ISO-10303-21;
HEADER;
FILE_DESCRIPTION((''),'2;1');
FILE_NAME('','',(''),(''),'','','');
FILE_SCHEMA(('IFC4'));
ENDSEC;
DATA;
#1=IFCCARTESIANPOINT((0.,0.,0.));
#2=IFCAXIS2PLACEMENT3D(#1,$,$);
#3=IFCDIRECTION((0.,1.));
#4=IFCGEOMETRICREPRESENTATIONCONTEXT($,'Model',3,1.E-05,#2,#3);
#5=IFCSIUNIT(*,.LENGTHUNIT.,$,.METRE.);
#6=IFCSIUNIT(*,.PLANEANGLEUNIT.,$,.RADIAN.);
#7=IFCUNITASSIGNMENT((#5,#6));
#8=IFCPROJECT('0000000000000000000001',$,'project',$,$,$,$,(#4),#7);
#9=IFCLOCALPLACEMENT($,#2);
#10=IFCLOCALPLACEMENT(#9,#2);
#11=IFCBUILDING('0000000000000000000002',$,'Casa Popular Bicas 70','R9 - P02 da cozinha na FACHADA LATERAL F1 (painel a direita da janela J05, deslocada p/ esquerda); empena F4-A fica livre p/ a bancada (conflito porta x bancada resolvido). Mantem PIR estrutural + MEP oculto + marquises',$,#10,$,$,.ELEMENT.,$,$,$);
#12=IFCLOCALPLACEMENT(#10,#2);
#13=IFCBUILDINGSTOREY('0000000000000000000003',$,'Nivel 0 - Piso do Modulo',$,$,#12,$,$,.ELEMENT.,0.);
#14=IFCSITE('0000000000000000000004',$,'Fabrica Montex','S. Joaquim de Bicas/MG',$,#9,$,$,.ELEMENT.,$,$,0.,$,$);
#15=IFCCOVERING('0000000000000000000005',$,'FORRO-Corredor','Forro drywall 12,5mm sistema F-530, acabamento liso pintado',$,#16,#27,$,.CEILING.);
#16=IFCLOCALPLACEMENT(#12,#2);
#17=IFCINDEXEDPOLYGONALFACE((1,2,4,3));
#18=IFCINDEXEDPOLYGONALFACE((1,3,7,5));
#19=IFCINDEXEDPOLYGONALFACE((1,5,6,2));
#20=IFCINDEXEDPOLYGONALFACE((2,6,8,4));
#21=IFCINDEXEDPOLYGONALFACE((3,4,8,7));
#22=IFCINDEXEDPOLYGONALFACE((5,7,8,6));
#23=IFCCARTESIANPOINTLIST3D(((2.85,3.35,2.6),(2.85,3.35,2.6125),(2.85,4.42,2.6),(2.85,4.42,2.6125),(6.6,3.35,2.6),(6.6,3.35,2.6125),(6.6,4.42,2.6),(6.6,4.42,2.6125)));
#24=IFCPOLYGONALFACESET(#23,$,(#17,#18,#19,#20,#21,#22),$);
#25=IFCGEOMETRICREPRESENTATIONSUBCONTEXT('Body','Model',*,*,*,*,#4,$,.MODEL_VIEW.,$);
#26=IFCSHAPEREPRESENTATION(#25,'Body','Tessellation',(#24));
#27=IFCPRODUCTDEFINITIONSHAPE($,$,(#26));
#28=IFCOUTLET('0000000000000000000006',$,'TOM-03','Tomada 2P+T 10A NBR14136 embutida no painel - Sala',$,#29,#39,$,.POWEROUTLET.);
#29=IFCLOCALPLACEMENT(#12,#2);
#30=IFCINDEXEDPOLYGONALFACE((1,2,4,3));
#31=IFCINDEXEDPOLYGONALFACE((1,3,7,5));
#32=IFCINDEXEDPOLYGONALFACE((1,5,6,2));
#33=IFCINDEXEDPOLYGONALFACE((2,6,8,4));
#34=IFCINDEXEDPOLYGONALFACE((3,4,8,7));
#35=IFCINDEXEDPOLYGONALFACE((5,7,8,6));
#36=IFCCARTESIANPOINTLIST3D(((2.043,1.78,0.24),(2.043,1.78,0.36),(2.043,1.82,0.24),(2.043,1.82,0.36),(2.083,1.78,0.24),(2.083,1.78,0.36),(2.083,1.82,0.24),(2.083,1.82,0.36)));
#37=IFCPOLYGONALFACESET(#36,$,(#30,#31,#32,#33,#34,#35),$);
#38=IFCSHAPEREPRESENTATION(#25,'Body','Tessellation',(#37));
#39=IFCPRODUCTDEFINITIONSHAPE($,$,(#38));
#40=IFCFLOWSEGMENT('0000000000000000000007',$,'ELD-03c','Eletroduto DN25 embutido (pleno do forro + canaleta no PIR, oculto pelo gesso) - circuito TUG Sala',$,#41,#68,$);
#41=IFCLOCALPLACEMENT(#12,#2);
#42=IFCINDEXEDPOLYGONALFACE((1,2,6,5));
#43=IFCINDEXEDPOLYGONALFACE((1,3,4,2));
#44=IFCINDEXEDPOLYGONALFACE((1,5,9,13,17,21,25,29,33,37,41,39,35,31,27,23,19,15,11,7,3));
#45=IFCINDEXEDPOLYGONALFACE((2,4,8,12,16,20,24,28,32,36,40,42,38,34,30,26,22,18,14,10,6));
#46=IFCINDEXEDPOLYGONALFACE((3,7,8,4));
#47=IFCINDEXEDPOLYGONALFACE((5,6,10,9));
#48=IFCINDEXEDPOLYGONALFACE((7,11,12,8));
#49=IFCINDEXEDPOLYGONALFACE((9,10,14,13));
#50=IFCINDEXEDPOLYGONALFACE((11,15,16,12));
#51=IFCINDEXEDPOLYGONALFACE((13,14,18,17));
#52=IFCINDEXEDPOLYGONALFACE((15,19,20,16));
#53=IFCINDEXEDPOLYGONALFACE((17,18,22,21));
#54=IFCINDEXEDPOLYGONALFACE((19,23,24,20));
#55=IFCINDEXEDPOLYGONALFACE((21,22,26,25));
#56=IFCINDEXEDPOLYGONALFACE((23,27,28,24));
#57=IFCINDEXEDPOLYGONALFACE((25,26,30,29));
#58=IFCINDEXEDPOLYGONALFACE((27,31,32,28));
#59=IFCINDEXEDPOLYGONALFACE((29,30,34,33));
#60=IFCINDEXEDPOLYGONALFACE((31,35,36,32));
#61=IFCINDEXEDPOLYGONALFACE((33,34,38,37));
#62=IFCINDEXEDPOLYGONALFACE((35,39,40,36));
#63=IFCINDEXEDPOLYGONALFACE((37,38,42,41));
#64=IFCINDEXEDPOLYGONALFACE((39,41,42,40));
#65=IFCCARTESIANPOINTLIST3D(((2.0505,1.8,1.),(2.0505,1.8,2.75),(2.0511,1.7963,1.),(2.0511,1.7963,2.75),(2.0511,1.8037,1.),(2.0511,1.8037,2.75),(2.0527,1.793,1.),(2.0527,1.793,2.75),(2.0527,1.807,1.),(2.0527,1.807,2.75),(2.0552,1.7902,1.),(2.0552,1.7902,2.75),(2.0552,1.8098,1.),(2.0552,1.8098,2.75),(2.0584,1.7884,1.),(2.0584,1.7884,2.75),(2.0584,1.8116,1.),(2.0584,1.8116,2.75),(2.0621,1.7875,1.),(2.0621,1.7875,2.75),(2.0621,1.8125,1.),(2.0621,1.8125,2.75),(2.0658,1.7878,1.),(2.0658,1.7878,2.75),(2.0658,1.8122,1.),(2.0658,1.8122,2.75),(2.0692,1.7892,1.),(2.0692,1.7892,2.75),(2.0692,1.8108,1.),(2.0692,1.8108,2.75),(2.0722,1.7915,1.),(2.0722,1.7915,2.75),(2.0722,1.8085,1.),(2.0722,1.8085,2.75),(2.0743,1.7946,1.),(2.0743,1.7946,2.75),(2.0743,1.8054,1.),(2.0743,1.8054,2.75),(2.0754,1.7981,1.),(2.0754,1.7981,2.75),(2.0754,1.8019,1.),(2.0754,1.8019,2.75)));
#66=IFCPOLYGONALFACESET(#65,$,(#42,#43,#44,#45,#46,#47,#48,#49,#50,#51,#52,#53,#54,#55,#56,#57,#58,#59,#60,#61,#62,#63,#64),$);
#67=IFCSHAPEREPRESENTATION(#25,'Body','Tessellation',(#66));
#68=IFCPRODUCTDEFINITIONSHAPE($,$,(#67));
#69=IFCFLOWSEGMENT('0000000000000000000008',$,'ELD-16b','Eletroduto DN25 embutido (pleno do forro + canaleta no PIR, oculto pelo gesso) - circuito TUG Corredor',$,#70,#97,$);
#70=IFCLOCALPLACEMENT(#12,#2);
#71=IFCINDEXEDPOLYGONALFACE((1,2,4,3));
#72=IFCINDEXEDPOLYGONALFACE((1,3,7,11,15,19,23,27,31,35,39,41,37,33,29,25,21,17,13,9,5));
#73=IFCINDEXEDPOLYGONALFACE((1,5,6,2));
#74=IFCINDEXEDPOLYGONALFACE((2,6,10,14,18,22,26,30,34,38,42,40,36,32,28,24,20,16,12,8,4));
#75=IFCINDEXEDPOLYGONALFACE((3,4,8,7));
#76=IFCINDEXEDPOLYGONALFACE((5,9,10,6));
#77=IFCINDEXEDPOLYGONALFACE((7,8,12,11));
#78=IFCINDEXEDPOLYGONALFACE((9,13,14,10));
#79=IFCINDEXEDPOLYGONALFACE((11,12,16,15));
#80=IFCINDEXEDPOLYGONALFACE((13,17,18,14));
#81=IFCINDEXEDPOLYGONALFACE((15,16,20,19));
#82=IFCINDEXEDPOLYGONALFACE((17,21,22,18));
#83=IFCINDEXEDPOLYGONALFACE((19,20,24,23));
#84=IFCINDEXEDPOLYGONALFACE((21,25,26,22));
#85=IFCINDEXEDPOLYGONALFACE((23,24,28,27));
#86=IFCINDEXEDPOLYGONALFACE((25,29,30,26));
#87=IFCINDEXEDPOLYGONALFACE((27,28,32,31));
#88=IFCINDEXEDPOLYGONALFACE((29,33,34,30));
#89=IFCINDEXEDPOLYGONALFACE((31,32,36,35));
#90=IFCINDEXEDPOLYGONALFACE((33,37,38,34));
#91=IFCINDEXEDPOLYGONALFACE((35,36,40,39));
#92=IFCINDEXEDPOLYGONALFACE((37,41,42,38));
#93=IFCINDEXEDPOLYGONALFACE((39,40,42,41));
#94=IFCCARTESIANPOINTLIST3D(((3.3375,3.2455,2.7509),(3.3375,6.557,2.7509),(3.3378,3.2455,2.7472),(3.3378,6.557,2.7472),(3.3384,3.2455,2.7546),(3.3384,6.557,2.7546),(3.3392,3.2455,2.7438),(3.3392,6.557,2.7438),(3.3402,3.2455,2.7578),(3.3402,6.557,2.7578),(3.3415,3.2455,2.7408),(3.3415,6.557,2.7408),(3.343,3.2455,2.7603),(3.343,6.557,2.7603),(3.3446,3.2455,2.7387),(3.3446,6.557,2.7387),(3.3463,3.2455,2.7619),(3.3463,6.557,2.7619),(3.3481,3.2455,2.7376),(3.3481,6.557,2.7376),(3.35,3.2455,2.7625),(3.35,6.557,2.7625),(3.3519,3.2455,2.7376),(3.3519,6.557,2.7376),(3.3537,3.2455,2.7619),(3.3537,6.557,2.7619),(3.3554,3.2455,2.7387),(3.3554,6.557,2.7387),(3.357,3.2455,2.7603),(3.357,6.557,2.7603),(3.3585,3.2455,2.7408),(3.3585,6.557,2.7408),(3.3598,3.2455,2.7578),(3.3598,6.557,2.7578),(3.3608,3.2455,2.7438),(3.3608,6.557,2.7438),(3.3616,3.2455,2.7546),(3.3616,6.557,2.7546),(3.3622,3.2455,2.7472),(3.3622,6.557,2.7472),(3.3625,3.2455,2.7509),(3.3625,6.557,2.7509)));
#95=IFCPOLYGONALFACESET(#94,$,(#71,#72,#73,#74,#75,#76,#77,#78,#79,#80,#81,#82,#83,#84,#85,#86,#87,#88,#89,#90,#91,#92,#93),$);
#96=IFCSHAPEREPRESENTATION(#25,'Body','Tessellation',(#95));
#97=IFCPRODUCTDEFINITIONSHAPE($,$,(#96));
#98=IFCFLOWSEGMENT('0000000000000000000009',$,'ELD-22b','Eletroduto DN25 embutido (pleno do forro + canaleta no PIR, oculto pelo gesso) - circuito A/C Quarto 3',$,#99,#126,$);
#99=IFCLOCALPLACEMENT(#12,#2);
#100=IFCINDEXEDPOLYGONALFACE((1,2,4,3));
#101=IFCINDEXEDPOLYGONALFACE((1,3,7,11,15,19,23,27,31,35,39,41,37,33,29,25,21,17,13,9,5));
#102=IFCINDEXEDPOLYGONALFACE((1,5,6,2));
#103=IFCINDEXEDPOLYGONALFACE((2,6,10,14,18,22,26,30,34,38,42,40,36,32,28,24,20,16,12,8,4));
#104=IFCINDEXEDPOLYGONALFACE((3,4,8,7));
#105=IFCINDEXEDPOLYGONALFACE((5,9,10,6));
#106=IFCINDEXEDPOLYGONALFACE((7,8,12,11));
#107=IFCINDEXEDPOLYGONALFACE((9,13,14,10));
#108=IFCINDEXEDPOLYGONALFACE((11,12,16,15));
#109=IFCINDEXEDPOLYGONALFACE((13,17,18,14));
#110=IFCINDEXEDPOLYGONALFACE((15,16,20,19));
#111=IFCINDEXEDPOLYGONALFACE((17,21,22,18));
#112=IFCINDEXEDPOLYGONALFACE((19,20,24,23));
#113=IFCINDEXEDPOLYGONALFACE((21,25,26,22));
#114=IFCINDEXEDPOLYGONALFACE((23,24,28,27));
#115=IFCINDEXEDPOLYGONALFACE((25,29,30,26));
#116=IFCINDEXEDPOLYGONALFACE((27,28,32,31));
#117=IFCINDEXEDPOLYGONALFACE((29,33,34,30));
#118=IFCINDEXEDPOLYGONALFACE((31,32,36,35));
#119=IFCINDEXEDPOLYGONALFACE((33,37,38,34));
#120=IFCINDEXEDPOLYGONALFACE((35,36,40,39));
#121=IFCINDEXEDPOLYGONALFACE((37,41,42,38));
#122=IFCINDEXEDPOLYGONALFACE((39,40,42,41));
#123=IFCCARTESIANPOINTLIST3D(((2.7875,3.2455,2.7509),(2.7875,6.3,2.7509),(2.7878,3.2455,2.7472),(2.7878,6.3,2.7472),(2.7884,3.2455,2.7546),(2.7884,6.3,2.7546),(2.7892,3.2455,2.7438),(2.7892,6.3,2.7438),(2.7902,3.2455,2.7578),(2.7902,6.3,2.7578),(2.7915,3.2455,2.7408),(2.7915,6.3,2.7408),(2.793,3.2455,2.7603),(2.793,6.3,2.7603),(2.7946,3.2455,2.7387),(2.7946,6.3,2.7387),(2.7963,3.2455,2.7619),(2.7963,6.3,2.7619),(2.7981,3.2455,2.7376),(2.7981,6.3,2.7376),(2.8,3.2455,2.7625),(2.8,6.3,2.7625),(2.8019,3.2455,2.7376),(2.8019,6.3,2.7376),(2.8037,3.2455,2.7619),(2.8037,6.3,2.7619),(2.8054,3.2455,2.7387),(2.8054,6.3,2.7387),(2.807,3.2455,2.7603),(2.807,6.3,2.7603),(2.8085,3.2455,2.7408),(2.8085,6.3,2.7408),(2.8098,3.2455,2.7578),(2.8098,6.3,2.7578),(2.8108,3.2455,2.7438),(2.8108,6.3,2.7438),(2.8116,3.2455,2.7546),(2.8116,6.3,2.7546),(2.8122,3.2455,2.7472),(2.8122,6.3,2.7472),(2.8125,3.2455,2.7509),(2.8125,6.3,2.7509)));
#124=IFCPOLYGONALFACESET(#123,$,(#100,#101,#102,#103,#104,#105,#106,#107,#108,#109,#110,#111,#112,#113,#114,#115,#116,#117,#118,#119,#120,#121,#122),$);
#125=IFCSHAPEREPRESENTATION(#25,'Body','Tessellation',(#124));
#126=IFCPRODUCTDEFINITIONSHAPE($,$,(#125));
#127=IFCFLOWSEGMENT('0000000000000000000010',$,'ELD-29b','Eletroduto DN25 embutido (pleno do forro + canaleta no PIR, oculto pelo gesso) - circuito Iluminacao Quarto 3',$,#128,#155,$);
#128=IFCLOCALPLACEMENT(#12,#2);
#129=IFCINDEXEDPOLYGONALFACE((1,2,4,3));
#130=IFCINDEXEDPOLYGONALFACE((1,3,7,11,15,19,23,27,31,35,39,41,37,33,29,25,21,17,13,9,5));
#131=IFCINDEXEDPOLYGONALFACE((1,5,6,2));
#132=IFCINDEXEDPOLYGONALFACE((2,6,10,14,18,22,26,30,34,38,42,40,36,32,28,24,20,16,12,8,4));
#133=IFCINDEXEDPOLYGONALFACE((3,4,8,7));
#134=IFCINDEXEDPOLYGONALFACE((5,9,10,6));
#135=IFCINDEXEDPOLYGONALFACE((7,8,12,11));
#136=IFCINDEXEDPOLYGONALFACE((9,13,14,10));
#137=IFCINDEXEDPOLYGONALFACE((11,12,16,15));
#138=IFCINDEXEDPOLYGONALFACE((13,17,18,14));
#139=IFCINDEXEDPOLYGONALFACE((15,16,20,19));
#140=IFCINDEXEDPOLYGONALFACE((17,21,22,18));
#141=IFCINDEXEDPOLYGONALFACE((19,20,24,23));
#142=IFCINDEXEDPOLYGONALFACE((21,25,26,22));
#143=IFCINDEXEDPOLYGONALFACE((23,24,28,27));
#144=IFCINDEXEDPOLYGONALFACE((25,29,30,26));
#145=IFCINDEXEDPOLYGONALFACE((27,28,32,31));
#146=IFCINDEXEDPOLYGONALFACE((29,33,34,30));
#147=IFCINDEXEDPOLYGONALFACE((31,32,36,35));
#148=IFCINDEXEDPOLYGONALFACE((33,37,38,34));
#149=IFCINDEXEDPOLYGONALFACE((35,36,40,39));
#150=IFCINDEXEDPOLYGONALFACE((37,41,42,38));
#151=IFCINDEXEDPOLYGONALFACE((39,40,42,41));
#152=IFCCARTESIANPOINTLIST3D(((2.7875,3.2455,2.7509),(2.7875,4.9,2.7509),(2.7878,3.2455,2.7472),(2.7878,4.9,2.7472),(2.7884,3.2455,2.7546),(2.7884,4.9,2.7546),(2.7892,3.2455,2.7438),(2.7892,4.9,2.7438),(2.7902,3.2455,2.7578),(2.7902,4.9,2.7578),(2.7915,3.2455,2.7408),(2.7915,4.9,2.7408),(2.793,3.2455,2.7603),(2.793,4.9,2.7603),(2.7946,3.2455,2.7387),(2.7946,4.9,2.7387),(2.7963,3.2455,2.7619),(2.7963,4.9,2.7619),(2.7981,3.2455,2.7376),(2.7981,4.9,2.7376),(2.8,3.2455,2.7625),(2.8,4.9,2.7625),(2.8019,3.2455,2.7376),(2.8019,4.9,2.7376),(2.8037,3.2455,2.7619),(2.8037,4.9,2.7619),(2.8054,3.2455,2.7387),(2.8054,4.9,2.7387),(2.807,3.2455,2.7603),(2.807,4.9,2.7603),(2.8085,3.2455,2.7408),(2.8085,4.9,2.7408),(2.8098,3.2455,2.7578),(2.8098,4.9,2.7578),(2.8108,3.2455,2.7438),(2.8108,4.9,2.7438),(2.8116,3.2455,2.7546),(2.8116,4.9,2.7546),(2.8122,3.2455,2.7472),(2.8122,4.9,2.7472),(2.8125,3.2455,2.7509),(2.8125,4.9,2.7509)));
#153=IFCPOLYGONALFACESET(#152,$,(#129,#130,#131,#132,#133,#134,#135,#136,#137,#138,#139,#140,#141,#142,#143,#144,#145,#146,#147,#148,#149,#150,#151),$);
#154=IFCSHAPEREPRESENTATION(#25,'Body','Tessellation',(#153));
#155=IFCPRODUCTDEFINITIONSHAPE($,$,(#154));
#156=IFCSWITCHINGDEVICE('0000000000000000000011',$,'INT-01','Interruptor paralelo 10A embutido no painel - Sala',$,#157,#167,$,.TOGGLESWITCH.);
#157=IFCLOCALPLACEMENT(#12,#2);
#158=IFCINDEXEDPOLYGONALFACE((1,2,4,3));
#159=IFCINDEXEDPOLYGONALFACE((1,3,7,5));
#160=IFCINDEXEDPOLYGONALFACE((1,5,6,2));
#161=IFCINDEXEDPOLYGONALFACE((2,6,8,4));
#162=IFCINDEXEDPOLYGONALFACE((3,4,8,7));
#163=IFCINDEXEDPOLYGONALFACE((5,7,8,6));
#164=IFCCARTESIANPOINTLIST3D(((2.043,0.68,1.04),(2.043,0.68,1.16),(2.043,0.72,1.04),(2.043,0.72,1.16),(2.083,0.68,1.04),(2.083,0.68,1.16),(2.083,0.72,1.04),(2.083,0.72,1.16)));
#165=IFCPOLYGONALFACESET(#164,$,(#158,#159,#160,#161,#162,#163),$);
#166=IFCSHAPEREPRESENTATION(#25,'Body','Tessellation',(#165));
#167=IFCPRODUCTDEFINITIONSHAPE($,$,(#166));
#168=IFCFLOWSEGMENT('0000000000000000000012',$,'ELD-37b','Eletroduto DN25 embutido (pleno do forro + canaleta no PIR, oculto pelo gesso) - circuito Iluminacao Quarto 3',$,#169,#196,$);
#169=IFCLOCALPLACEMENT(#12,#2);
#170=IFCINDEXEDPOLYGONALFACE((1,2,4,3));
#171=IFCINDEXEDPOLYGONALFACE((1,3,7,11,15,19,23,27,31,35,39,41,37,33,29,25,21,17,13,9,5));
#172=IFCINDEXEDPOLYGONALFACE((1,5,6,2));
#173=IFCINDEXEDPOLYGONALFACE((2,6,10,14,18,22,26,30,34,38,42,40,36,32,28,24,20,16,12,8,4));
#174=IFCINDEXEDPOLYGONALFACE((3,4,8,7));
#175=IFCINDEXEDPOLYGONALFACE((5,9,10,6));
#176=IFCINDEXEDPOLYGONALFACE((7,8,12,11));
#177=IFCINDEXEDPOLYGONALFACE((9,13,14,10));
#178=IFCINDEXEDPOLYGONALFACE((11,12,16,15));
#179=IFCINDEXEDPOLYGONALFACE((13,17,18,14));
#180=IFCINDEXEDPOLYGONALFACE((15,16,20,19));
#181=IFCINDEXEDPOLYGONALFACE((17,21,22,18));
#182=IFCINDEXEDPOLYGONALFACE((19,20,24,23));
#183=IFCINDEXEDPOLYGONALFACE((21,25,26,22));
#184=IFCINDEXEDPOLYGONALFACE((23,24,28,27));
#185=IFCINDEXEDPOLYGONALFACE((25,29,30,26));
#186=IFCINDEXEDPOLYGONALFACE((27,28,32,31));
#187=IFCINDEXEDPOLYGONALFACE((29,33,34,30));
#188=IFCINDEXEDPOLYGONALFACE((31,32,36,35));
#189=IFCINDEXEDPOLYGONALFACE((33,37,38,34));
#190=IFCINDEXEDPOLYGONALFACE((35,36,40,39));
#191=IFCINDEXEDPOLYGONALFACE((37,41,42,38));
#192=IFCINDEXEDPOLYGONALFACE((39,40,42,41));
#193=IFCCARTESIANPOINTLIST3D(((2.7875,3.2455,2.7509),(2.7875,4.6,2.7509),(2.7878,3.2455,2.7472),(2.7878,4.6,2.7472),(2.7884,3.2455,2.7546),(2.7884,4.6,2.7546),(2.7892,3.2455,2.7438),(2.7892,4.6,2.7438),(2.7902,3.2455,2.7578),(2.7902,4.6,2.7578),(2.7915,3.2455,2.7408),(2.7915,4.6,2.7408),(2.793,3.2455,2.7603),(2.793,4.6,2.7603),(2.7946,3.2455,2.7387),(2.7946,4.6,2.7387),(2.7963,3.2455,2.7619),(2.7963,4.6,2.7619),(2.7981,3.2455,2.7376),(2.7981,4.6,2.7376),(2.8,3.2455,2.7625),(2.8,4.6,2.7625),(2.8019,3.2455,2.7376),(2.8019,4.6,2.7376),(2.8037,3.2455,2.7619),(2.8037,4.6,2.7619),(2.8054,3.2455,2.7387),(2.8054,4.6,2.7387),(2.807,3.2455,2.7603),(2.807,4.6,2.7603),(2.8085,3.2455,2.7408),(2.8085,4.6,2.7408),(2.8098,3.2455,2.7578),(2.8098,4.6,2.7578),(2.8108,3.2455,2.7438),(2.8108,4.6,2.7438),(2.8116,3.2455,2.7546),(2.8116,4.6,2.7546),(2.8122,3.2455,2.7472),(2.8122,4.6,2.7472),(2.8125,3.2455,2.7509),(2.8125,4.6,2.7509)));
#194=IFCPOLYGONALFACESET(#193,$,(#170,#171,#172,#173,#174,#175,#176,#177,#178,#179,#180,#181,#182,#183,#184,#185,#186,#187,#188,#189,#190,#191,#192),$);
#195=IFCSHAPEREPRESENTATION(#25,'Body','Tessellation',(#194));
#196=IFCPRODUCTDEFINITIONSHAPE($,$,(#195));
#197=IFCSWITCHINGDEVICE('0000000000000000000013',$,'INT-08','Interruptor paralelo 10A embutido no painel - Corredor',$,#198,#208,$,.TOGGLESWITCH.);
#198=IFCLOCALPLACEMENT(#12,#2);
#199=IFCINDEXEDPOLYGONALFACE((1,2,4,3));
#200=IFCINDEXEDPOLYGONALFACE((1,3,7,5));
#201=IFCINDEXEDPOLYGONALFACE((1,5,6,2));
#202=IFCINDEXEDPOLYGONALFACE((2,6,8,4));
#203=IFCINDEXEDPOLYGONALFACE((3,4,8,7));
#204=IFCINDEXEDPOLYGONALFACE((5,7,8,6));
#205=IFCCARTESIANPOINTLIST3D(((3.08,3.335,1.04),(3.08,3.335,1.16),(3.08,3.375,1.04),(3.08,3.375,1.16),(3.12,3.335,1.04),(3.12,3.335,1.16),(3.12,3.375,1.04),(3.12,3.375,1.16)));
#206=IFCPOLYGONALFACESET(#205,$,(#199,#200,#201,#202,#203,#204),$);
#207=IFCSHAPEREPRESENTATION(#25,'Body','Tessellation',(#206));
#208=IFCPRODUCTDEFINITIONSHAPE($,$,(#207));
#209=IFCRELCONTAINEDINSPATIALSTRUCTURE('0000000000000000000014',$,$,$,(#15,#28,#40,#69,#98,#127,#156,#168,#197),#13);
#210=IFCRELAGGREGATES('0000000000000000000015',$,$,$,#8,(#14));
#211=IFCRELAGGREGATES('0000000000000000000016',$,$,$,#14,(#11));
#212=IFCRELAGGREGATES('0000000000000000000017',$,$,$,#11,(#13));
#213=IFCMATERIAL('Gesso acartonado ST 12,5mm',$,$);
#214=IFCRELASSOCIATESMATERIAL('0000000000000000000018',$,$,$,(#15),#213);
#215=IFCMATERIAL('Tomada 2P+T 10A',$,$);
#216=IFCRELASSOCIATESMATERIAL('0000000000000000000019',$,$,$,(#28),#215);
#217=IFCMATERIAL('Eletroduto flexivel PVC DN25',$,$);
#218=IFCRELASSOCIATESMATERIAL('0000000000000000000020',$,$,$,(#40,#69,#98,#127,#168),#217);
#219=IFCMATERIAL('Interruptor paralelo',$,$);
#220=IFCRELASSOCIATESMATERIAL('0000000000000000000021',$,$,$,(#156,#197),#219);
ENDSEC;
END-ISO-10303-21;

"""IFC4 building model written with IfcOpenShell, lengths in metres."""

from ifc_helpers import new_model, si_unit, direction, frame, frame_2d, origin, origin_2d, place, context, subcontext, project, spatial, rectangle, circle, extrude, material, element, save


model = new_model("IFC4")

# Units and contexts
model_context = context("Model", 3, precision=1e-05, world=origin(), true_north=direction((0.0, 1.0)))
body_context = subcontext(model_context, "Body", "Model", "MODEL_VIEW")
ifc_project = project(units=[si_unit("LENGTHUNIT", "METRE"), si_unit("PLANEANGLEUNIT", "RADIAN")], contexts=[model_context])

# Site, building, storey
site_placement = place(None, origin())
site = spatial("IfcSite", under=ifc_project, at=site_placement, Name="Fabrica Montex", Description="S. Joaquim de Bicas/MG", CompositionType="ELEMENT", RefElevation=0.0)
building_placement = place(site_placement, origin())
building = spatial("IfcBuilding", under=site, at=building_placement, Name="Casa Popular Bicas 70", Description="R9 - P02 da cozinha na FACHADA LATERAL F1 (painel a direita da janela J05, deslocada p/ esquerda); empena F4-A fica livre p/ a bancada (conflito porta x bancada resolvido). Mantem PIR estrutural + MEP oculto + marquises", CompositionType="ELEMENT")
storey_placement = place(building_placement, origin())
storey = spatial("IfcBuildingStorey", under=building, at=storey_placement, Name="Nivel 0 - Piso do Modulo", CompositionType="ELEMENT", Elevation=0.0)

# Covering
ifc_material_1 = material(Name="Gesso acartonado ST 12,5mm")
covering_1_placement = place(storey_placement, frame((2.85, 3.35, 2.6)))
element("IfcCovering", 1, at=covering_1_placement, inside=storey, material=ifc_material_1, Name="FORRO-Corredor", Description="Forro drywall 12,5mm sistema F-530, acabamento liso pintado", PredefinedType="CEILING", context=body_context, shape_type="SweptSolid", body=[
    extrude(rectangle(XDim=3.75, YDim=1.07, at=frame_2d((1.875, 0.535))), origin(), (0.0, 0.0, 1.0), 0.0125),
])

# Outlet
ifc_material_2 = material(Name="Tomada 2P+T 10A")
outlet_placement = place(None, frame((2.083, 1.82, 0.24), z_axis=(0.0, 0.0, 1.0), x_axis=(-1.0, 0.0, 0.0)))
element("IfcOutlet", 2, at=outlet_placement, inside=storey, material=ifc_material_2, Name="TOM-03", Description="Tomada 2P+T 10A NBR14136 embutida no painel - Sala", PredefinedType="POWEROUTLET", context=body_context, shape_type="SweptSolid", body=[
    extrude(rectangle(XDim=0.04, YDim=0.04, at=frame_2d((0.02, 0.02))), origin(), (0.0, 0.0, 1.0), 0.12),
])

# Flow segments
ifc_material_3 = material(Name="Eletroduto flexivel PVC DN25")
flow_segment_1_placement = place(None, frame((2.063, 1.8, 2.75), z_axis=(0.0, 0.0, -1.0), x_axis=(-1.0, 0.0, 0.0)))
element("IfcFlowSegment", 3, at=flow_segment_1_placement, inside=storey, material=ifc_material_3, Name="ELD-03c", Description="Eletroduto DN25 embutido (pleno do forro + canaleta no PIR, oculto pelo gesso) - circuito TUG Sala", context=body_context, shape_type="SweptSolid", body=[
    extrude(circle(Radius=0.0125, at=origin_2d()), origin(), (0.0, 0.0, 1.0), 1.75),
])
flow_segment_2_placement = place(storey_placement, frame((3.35, 3.2455, 2.75), z_axis=(0.0, 1.0, 0.0), x_axis=(0.0, 0.0, 1.0)))
element("IfcFlowSegment", 4, at=flow_segment_2_placement, inside=storey, material=ifc_material_3, Name="ELD-16b", Description="Eletroduto DN25 embutido (pleno do forro + canaleta no PIR, oculto pelo gesso) - circuito TUG Corredor", context=body_context, shape_type="SweptSolid", body=[
    extrude(circle(Radius=0.0125, at=origin_2d()), origin(), (0.0, 0.0, 1.0), 3.3115),
])
flow_segment_3_placement = place(storey_placement, frame((2.8, 3.2455, 2.75), z_axis=(0.0, 1.0, 0.0), x_axis=(0.0, 0.0, 1.0)))
element("IfcFlowSegment", 5, at=flow_segment_3_placement, inside=storey, material=ifc_material_3, Name="ELD-22b", Description="Eletroduto DN25 embutido (pleno do forro + canaleta no PIR, oculto pelo gesso) - circuito A/C Quarto 3", context=body_context, shape_type="SweptSolid", body=[
    extrude(circle(Radius=0.0125, at=origin_2d()), origin(), (0.0, 0.0, 1.0), 3.0545),
])
flow_segment_4_placement = place(storey_placement, frame((2.8, 3.2455, 2.75), z_axis=(0.0, 1.0, 0.0), x_axis=(0.0, 0.0, 1.0)))
element("IfcFlowSegment", 6, at=flow_segment_4_placement, inside=storey, material=ifc_material_3, Name="ELD-29b", Description="Eletroduto DN25 embutido (pleno do forro + canaleta no PIR, oculto pelo gesso) - circuito Iluminacao Quarto 3", context=body_context, shape_type="SweptSolid", body=[
    extrude(circle(Radius=0.0125, at=origin_2d()), origin(), (0.0, 0.0, 1.0), 1.6545),
])

# Switching device
ifc_material_4 = material(Name="Interruptor paralelo")
switching_device_1_placement = place(None, frame((2.083, 0.72, 1.04), z_axis=(0.0, 0.0, 1.0), x_axis=(-1.0, 0.0, 0.0)))
element("IfcSwitchingDevice", 7, at=switching_device_1_placement, inside=storey, material=ifc_material_4, Name="INT-01", Description="Interruptor paralelo 10A embutido no painel - Sala", PredefinedType="TOGGLESWITCH", context=body_context, shape_type="SweptSolid", body=[
    extrude(rectangle(XDim=0.04, YDim=0.04, at=frame_2d((0.02, 0.02))), origin(), (0.0, 0.0, 1.0), 0.12),
])

# Flow segment
flow_segment_5_placement = place(storey_placement, frame((2.8, 3.2455, 2.75), z_axis=(0.0, 1.0, 0.0), x_axis=(0.0, 0.0, 1.0)))
element("IfcFlowSegment", 8, at=flow_segment_5_placement, inside=storey, material=ifc_material_3, Name="ELD-37b", Description="Eletroduto DN25 embutido (pleno do forro + canaleta no PIR, oculto pelo gesso) - circuito Iluminacao Quarto 3", context=body_context, shape_type="SweptSolid", body=[
    extrude(circle(Radius=0.0125, at=origin_2d()), origin(), (0.0, 0.0, 1.0), 1.3545),
])

# Switching device
switching_device_2_placement = place(storey_placement, frame((3.08, 3.335, 1.04)))
element("IfcSwitchingDevice", 9, at=switching_device_2_placement, inside=storey, material=ifc_material_4, Name="INT-08", Description="Interruptor paralelo 10A embutido no painel - Corredor", PredefinedType="TOGGLESWITCH", context=body_context, shape_type="SweptSolid", body=[
    extrude(rectangle(XDim=0.04, YDim=0.04, at=frame_2d((0.02, 0.02))), origin(), (0.0, 0.0, 1.0), 0.12),
])

save(model, "model.ifc")
